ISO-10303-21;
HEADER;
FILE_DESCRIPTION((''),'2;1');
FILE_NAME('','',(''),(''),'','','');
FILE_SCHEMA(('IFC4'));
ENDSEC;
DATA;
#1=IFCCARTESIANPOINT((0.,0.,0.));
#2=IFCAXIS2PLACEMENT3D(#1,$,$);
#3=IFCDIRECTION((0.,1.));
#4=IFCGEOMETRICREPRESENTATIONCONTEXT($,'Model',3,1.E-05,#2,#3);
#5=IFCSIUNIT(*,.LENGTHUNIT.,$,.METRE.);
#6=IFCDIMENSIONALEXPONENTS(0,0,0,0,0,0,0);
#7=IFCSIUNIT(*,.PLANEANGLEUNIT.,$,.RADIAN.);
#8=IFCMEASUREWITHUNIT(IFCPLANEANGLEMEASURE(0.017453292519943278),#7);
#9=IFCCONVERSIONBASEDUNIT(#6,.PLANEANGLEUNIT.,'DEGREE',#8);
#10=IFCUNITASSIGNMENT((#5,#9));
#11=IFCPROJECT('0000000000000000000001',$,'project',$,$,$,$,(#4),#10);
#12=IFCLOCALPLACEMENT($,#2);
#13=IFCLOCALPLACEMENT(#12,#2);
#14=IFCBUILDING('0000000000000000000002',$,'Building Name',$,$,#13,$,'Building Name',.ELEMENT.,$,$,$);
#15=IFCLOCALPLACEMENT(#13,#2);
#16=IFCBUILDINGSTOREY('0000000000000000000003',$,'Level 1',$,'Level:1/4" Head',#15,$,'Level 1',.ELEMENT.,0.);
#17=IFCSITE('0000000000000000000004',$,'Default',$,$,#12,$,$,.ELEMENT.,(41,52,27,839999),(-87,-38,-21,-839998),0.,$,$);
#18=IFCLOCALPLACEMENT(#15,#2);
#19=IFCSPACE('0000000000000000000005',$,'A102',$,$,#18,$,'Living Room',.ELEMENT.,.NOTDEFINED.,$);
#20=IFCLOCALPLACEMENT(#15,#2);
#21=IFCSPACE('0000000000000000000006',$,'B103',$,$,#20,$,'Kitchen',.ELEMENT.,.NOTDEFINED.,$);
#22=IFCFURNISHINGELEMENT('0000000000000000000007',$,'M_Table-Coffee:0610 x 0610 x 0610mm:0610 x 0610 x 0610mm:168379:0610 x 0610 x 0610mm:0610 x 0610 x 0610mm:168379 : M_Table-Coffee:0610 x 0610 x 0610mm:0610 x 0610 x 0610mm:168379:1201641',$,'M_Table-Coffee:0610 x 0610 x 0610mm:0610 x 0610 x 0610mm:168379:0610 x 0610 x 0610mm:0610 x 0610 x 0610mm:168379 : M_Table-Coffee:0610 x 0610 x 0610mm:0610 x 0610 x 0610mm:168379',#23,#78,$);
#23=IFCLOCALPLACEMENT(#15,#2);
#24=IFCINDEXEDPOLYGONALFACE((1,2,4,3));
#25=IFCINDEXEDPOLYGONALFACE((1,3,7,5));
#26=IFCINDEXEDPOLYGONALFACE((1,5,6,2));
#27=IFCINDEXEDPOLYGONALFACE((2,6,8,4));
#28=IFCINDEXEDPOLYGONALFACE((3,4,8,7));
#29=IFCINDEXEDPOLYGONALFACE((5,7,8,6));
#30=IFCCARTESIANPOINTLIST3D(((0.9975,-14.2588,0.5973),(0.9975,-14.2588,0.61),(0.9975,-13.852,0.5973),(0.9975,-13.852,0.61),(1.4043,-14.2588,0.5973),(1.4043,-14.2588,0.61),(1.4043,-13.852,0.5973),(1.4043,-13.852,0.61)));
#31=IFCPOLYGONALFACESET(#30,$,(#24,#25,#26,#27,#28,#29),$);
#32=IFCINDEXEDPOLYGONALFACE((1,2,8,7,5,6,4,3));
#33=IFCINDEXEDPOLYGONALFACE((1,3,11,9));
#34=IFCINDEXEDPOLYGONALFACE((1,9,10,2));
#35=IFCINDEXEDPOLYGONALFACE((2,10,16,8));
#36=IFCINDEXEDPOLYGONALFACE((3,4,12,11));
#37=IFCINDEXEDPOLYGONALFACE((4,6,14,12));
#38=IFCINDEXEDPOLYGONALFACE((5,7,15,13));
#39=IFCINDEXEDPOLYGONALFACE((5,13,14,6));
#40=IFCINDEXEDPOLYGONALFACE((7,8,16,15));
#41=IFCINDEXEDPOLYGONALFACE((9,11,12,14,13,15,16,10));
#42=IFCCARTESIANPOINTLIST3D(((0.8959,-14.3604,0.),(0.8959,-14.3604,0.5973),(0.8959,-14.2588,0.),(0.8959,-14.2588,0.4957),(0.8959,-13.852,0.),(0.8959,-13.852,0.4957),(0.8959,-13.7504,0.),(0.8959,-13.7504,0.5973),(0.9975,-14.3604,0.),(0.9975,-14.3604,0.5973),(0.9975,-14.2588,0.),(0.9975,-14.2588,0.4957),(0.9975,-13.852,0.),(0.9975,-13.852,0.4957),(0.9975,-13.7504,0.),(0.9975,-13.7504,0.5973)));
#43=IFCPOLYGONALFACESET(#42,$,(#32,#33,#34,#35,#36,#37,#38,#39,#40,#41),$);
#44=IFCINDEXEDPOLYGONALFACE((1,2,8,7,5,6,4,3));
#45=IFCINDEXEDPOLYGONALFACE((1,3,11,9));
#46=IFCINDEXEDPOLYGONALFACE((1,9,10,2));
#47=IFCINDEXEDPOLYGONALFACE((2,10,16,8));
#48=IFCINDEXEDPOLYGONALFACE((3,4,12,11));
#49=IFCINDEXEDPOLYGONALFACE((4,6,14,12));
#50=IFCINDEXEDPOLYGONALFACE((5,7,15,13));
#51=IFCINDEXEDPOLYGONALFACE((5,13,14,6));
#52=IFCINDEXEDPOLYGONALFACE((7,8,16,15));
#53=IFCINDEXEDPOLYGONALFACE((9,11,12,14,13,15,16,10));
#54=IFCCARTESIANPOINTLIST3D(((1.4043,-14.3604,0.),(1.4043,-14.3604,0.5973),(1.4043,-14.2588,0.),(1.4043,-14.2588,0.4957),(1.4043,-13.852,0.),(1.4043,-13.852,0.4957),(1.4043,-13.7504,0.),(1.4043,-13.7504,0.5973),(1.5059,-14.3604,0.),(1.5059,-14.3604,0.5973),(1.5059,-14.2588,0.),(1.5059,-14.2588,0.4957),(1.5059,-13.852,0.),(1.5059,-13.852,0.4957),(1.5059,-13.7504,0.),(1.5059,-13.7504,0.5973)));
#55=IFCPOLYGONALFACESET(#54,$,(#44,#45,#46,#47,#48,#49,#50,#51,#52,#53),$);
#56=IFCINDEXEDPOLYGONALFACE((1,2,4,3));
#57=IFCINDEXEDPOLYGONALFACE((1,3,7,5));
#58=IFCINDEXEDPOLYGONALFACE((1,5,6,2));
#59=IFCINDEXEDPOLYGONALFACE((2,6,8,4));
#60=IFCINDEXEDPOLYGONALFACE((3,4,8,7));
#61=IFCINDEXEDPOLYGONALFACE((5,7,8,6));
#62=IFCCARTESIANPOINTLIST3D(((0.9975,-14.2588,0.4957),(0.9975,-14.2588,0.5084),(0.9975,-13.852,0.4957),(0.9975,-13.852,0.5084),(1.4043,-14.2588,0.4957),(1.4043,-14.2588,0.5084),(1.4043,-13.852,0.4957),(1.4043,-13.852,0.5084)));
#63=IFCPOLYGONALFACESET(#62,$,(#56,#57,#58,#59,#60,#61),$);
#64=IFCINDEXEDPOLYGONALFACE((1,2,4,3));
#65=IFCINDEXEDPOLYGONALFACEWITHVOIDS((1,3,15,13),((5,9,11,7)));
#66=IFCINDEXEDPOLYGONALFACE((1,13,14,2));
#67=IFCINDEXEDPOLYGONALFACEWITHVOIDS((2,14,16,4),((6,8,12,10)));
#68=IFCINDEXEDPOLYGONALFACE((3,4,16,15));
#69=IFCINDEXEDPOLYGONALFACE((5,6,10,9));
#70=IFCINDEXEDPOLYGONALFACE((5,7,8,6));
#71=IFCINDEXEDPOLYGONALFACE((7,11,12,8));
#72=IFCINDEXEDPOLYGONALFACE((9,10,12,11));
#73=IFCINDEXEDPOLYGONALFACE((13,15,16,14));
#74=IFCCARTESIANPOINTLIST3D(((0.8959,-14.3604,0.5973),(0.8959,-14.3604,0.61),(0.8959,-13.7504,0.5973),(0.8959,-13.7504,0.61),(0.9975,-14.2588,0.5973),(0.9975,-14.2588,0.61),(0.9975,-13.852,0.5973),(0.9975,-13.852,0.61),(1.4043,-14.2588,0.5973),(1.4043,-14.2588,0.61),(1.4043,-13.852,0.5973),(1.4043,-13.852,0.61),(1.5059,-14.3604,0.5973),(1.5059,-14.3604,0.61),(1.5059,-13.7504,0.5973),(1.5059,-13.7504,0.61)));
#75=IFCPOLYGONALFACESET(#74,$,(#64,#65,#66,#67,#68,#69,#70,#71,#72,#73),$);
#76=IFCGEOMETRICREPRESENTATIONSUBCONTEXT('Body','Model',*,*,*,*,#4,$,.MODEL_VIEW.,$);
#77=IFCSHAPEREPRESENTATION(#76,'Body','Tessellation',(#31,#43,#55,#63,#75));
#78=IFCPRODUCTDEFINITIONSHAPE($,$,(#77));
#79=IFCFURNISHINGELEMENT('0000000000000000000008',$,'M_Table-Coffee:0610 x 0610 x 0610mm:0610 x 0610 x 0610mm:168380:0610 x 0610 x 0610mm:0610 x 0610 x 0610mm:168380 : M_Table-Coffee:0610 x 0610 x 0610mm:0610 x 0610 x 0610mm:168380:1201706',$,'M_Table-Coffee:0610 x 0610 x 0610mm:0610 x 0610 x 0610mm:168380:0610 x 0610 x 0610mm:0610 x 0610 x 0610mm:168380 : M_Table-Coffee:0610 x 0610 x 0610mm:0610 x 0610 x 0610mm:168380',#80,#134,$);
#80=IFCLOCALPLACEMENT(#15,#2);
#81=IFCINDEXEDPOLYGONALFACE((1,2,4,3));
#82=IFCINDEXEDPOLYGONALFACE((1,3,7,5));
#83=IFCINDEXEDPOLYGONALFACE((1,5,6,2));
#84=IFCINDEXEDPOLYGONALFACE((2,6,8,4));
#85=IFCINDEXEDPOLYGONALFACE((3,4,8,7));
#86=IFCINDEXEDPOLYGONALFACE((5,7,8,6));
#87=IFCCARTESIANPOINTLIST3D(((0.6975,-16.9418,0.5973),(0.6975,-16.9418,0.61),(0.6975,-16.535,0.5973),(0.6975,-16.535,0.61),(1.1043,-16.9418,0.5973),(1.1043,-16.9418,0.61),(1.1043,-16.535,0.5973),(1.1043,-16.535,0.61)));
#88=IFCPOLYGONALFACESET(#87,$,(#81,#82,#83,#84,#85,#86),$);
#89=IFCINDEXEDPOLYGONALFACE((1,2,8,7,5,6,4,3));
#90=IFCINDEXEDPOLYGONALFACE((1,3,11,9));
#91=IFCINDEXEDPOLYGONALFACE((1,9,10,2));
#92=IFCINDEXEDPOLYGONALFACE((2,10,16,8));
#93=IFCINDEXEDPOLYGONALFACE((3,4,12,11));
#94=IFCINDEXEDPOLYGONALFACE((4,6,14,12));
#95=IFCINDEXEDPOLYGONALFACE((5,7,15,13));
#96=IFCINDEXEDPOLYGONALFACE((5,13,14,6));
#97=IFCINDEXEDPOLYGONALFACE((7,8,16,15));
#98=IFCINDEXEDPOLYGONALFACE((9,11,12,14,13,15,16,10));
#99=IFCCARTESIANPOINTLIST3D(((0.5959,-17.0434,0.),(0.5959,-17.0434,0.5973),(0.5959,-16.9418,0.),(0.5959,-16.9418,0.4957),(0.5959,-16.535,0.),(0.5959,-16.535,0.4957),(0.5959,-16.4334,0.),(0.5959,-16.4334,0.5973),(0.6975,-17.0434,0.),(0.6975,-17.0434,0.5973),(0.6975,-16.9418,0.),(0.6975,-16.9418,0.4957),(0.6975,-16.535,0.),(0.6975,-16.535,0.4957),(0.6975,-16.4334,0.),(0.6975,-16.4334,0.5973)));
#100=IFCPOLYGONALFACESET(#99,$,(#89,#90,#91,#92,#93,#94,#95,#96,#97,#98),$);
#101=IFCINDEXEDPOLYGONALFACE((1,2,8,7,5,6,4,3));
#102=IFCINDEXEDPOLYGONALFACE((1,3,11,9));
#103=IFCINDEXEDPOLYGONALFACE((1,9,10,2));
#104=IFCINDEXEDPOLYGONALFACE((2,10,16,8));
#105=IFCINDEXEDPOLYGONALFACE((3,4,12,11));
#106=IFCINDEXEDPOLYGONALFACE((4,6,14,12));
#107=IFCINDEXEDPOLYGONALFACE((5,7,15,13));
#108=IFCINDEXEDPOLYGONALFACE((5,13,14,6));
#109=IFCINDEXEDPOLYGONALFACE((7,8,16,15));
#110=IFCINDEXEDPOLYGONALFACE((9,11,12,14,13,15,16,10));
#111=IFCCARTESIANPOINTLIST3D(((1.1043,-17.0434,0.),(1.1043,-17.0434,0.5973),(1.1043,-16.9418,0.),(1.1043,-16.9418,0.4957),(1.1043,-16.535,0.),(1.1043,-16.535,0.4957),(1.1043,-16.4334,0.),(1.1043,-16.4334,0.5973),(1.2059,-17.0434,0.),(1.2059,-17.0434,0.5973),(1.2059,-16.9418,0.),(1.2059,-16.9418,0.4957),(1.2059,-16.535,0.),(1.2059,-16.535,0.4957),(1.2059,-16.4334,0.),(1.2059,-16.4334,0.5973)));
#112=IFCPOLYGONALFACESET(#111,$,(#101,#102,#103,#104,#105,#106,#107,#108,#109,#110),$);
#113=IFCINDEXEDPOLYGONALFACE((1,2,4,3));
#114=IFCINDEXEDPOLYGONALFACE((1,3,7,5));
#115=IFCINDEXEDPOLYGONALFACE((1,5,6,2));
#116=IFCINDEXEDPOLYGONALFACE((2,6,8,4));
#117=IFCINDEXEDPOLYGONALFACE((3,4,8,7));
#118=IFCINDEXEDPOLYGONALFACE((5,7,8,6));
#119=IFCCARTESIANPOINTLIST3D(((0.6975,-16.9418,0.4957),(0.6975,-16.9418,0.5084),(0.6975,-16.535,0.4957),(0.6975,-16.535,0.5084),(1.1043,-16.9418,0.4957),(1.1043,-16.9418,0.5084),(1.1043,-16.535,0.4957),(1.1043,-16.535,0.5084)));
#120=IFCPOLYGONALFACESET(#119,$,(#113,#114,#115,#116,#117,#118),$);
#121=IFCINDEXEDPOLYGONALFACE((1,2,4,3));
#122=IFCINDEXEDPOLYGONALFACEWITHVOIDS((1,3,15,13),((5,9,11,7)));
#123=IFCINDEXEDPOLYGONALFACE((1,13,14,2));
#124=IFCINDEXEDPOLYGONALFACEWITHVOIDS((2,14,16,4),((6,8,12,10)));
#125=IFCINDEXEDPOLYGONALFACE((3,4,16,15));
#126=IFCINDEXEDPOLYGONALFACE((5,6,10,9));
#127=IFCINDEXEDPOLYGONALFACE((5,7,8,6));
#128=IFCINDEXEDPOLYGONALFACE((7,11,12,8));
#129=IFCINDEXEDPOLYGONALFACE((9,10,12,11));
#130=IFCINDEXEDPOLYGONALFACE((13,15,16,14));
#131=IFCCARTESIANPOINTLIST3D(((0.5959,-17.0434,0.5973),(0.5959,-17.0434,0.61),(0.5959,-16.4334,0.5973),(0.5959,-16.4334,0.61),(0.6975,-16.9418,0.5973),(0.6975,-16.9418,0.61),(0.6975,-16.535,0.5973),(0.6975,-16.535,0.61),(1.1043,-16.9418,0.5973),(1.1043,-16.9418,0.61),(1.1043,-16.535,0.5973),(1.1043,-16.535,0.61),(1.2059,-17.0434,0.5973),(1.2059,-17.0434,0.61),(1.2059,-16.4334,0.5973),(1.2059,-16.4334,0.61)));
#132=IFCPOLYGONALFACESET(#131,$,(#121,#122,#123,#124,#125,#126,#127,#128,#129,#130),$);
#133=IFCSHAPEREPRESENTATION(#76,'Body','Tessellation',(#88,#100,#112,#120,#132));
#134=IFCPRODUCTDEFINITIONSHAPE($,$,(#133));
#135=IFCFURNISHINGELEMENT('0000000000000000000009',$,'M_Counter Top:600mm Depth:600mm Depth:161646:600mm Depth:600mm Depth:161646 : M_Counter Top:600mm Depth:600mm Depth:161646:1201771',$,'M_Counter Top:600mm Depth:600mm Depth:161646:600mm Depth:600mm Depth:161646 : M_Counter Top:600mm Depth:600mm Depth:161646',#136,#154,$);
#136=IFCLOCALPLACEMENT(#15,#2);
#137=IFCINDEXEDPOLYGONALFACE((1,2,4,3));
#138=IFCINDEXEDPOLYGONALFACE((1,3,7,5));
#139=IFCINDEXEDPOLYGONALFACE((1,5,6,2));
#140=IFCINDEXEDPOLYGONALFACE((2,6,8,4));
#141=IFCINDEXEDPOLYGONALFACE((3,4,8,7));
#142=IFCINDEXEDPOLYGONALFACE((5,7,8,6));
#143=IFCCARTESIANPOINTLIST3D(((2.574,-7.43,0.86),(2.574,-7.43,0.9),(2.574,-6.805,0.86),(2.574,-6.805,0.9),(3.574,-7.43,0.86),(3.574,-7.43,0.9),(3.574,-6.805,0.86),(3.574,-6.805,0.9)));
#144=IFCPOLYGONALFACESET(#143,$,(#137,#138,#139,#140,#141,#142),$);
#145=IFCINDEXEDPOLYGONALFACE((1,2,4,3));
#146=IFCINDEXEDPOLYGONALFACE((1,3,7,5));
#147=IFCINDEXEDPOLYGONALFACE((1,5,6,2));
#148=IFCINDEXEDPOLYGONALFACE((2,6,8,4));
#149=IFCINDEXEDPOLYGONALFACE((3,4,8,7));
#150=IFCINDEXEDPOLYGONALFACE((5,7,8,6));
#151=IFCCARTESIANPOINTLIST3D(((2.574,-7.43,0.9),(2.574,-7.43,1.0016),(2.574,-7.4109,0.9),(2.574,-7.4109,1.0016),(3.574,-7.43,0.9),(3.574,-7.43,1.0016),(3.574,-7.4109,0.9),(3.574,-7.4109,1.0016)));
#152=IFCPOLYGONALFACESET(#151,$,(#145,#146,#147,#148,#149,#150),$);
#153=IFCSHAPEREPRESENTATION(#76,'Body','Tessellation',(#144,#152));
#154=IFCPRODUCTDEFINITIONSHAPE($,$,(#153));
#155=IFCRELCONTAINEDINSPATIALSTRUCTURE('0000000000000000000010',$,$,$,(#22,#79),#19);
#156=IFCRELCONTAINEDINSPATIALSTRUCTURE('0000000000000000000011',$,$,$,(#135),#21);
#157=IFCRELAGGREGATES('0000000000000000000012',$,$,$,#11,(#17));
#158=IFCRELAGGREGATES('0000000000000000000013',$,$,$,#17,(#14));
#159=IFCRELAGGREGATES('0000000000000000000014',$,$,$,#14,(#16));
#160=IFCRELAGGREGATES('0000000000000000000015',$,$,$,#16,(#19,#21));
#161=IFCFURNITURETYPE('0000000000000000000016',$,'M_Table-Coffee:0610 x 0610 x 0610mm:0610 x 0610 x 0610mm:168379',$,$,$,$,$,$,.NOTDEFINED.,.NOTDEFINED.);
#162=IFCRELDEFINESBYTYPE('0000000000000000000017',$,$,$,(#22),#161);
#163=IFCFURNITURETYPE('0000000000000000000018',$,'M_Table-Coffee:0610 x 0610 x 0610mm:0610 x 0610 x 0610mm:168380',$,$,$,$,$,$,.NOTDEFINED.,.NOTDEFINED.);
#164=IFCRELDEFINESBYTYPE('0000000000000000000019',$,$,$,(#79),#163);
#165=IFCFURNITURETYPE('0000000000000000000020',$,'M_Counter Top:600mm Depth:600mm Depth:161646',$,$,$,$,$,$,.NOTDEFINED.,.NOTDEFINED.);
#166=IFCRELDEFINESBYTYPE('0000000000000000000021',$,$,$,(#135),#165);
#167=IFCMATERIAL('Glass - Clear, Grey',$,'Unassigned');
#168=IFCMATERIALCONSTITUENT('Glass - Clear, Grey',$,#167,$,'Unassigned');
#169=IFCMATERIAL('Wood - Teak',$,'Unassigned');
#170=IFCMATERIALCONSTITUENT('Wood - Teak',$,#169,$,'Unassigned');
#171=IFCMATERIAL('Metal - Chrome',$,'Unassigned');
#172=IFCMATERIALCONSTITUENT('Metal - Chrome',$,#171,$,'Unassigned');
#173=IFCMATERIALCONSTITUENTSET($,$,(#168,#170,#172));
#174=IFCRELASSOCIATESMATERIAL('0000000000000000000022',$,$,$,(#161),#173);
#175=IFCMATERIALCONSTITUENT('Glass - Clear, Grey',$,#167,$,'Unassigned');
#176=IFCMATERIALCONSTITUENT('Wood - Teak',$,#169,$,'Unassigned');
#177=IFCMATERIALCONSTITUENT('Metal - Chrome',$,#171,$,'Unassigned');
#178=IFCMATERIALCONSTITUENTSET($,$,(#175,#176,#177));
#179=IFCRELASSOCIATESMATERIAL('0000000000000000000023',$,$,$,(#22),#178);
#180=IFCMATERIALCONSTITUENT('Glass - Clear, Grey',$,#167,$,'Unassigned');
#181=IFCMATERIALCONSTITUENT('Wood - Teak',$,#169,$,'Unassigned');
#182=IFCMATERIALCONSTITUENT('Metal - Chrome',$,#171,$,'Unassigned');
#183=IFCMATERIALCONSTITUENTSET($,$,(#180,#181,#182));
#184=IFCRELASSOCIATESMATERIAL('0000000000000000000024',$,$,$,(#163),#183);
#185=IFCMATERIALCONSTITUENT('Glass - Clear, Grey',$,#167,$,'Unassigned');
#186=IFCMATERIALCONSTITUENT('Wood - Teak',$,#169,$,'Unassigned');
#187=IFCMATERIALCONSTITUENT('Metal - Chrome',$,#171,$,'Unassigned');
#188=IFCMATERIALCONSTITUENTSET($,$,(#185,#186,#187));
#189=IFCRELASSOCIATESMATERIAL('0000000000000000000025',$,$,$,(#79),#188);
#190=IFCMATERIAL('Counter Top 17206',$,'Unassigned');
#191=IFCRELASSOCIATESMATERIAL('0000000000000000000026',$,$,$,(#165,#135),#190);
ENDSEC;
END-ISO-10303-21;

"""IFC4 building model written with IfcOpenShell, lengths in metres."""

from ifc_helpers import new_model, entity, si_unit, converted_unit, direction, frame, origin, place, context, subcontext, project, spatial, indexed_curve, outline, extrude, source, transform, mapped, material, constituent, constituent_set, type_object, type_shapes, element, save


model = new_model("IFC4")

# Units and contexts
model_context = context("Model", 3, precision=1e-05, world=origin(), true_north=direction((0.0, 1.0)))
body_context = subcontext(model_context, "Body", "Model", "MODEL_VIEW")
ifc_project = project(units=[si_unit("LENGTHUNIT", "METRE"), converted_unit("PLANEANGLEUNIT", "DEGREE", entity("IfcPlaneAngleMeasure", 0.017453292519943278), si_unit("PLANEANGLEUNIT", "RADIAN"), dimensions=[0, 0, 0, 0, 0, 0, 0])], contexts=[model_context])

# Site, building, storey
site_placement = place(None, origin())
site = spatial("IfcSite", under=ifc_project, at=site_placement, Name="Default", CompositionType="ELEMENT", RefLatitude=(41, 52, 27, 839999), RefLongitude=(-87, -38, -21, -839998), RefElevation=0.0)
building_placement = place(site_placement, origin())
building = spatial("IfcBuilding", under=site, at=building_placement, Name="Building Name", LongName="Building Name", CompositionType="ELEMENT")
storey_placement = place(building_placement, origin())
storey = spatial("IfcBuildingStorey", under=building, at=storey_placement, Name="Level 1", ObjectType="Level:1/4\" Head", LongName="Level 1", CompositionType="ELEMENT", Elevation=0.0)

# Shared definitions
ifc_material_1 = material(Name="Glass - Clear, Grey", Category="Unassigned")
ifc_material_2 = material(Name="Wood - Teak", Category="Unassigned")
ifc_material_3 = material(Name="Metal - Chrome", Category="Unassigned")

# Shared definitions
space_1_placement = place(storey_placement, origin())
space_1 = spatial("IfcSpace", under=storey, at=space_1_placement, Name="A102", LongName="Living Room", CompositionType="ELEMENT", PredefinedType="NOTDEFINED")

# Furnishing elements
ifc_constituent_1 = constituent(ifc_material_1, Name="Glass - Clear, Grey", Category="Unassigned")
ifc_constituent_2 = constituent(ifc_material_2, Name="Wood - Teak", Category="Unassigned")
ifc_constituent_3 = constituent(ifc_material_3, Name="Metal - Chrome", Category="Unassigned")
ifc_constituent_set_1 = constituent_set(constituents=[ifc_constituent_1, ifc_constituent_2, ifc_constituent_3])
ifc_constituent_4 = constituent(ifc_material_1, Name="Glass - Clear, Grey", Category="Unassigned")
ifc_constituent_5 = constituent(ifc_material_2, Name="Wood - Teak", Category="Unassigned")
ifc_constituent_6 = constituent(ifc_material_3, Name="Metal - Chrome", Category="Unassigned")
ifc_constituent_set_2 = constituent_set(constituents=[ifc_constituent_4, ifc_constituent_5, ifc_constituent_6])
furniture_type_1 = type_object("IfcFurnitureType", Name="M_Table-Coffee:0610 x 0610 x 0610mm:0610 x 0610 x 0610mm:168379", AssemblyPlace="NOTDEFINED", PredefinedType="NOTDEFINED", material=ifc_constituent_set_2)
shared_shape_1 = source(origin(), body_context, "Body", "SweptSolid", [
    extrude(outline(indexed_curve([(-0.2034, -0.2034), (0.2034, -0.2034), (0.2034, 0.2034), (-0.2034, 0.2034), (-0.2034, -0.2034)], self_intersect=False)), frame((1.2009, -14.0554, 0.5973), z_axis=(0.0, 0.0, 1.0), x_axis=(0.0, 1.0, 0.0)), (0.0, 0.0, 1.0), 0.0127),
    extrude(outline(indexed_curve([(-0.324, -0.305), (0.2732, -0.305), (0.2732, -0.2034), (-0.2225, -0.2034), (-0.2225, 0.2034), (0.2732, 0.2034), (0.2732, 0.305), (-0.324, 0.305), (-0.324, -0.305)], self_intersect=False)), frame((0.8959, -14.0554, 0.2732), z_axis=(1.0, 0.0, 0.0), x_axis=(0.0, 0.0, -1.0)), (0.0, 0.0, 1.0), 0.1016),
    extrude(outline(indexed_curve([(-0.305, -0.3241), (0.305, -0.3241), (0.305, 0.2733), (0.2034, 0.2733), (0.2034, -0.2224), (-0.2034, -0.2224), (-0.2034, 0.2733), (-0.305, 0.2733), (-0.305, -0.3241)], self_intersect=False)), frame((1.4043, -14.0554, 0.2733), z_axis=(1.0, 0.0, 0.0), x_axis=(0.0, -1.0, 0.0)), (0.0, 0.0, 1.0), 0.1016),
    extrude(outline(indexed_curve([(-0.2034, -0.2034), (0.2034, -0.2034), (0.2034, 0.2034), (-0.2034, 0.2034), (-0.2034, -0.2034)], self_intersect=False)), frame((1.2009, -14.0554, 0.4957), z_axis=(0.0, 0.0, 1.0), x_axis=(0.0, 1.0, 0.0)), (0.0, 0.0, 1.0), 0.0127),
    extrude(outline(indexed_curve([(-0.305, -0.305), (0.305, -0.305), (0.305, 0.305), (-0.305, 0.305), (-0.305, -0.305)], self_intersect=False), holes=[indexed_curve([(0.2034, 0.2034), (0.2034, -0.2034), (-0.2034, -0.2034), (-0.2034, 0.2034), (0.2034, 0.2034)], self_intersect=False)]), frame((1.2009, -14.0554, 0.5973), z_axis=(0.0, 0.0, 1.0), x_axis=(0.0, 1.0, 0.0)), (0.0, 0.0, 1.0), 0.0127),
])
type_shapes(furniture_type_1, [shared_shape_1])
furnishing_1_placement = place(space_1_placement, origin())
element("IfcFurnishingElement", 1, at=furnishing_1_placement, inside=space_1, type_object=furniture_type_1, material=ifc_constituent_set_1, Name="M_Table-Coffee:0610 x 0610 x 0610mm:0610 x 0610 x 0610mm:168379:0610 x 0610 x 0610mm:0610 x 0610 x 0610mm:168379 : M_Table-Coffee:0610 x 0610 x 0610mm:0610 x 0610 x 0610mm:168379:1201641", ObjectType="M_Table-Coffee:0610 x 0610 x 0610mm:0610 x 0610 x 0610mm:168379:0610 x 0610 x 0610mm:0610 x 0610 x 0610mm:168379 : M_Table-Coffee:0610 x 0610 x 0610mm:0610 x 0610 x 0610mm:168379", context=body_context, shape_type="MappedRepresentation", body=[
    mapped(shared_shape_1, transform((0.0, 0.0, 0.0), scale=1.0)),
])
ifc_constituent_7 = constituent(ifc_material_1, Name="Glass - Clear, Grey", Category="Unassigned")
ifc_constituent_8 = constituent(ifc_material_2, Name="Wood - Teak", Category="Unassigned")
ifc_constituent_9 = constituent(ifc_material_3, Name="Metal - Chrome", Category="Unassigned")
ifc_constituent_set_3 = constituent_set(constituents=[ifc_constituent_7, ifc_constituent_8, ifc_constituent_9])
ifc_constituent_10 = constituent(ifc_material_1, Name="Glass - Clear, Grey", Category="Unassigned")
ifc_constituent_11 = constituent(ifc_material_2, Name="Wood - Teak", Category="Unassigned")
ifc_constituent_12 = constituent(ifc_material_3, Name="Metal - Chrome", Category="Unassigned")
ifc_constituent_set_4 = constituent_set(constituents=[ifc_constituent_10, ifc_constituent_11, ifc_constituent_12])
furniture_type_2 = type_object("IfcFurnitureType", Name="M_Table-Coffee:0610 x 0610 x 0610mm:0610 x 0610 x 0610mm:168380", AssemblyPlace="NOTDEFINED", PredefinedType="NOTDEFINED", material=ifc_constituent_set_4)
shared_shape_2 = source(origin(), body_context, "Body", "SweptSolid", [
    extrude(outline(indexed_curve([(-0.2034, -0.2034), (0.2034, -0.2034), (0.2034, 0.2034), (-0.2034, 0.2034), (-0.2034, -0.2034)], self_intersect=False)), frame((0.9009, -16.7384, 0.5973), z_axis=(0.0, 0.0, 1.0), x_axis=(0.0, 1.0, 0.0)), (0.0, 0.0, 1.0), 0.0127),
    extrude(outline(indexed_curve([(-0.324, -0.305), (0.2732, -0.305), (0.2732, -0.2034), (-0.2225, -0.2034), (-0.2225, 0.2034), (0.2732, 0.2034), (0.2732, 0.305), (-0.324, 0.305), (-0.324, -0.305)], self_intersect=False)), frame((0.5959, -16.7384, 0.2732), z_axis=(1.0, 0.0, 0.0), x_axis=(0.0, 0.0, -1.0)), (0.0, 0.0, 1.0), 0.1016),
    extrude(outline(indexed_curve([(-0.305, -0.3241), (0.305, -0.3241), (0.305, 0.2733), (0.2034, 0.2733), (0.2034, -0.2224), (-0.2034, -0.2224), (-0.2034, 0.2733), (-0.305, 0.2733), (-0.305, -0.3241)], self_intersect=False)), frame((1.1043, -16.7384, 0.2733), z_axis=(1.0, 0.0, 0.0), x_axis=(0.0, -1.0, 0.0)), (0.0, 0.0, 1.0), 0.1016),
    extrude(outline(indexed_curve([(-0.2034, -0.2034), (0.2034, -0.2034), (0.2034, 0.2034), (-0.2034, 0.2034), (-0.2034, -0.2034)], self_intersect=False)), frame((0.9009, -16.7384, 0.4957), z_axis=(0.0, 0.0, 1.0), x_axis=(0.0, 1.0, 0.0)), (0.0, 0.0, 1.0), 0.0127),
    extrude(outline(indexed_curve([(-0.305, -0.305), (0.305, -0.305), (0.305, 0.305), (-0.305, 0.305), (-0.305, -0.305)], self_intersect=False), holes=[indexed_curve([(0.2034, 0.2034), (0.2034, -0.2034), (-0.2034, -0.2034), (-0.2034, 0.2034), (0.2034, 0.2034)], self_intersect=False)]), frame((0.9009, -16.7384, 0.5973), z_axis=(0.0, 0.0, 1.0), x_axis=(0.0, 1.0, 0.0)), (0.0, 0.0, 1.0), 0.0127),
])
type_shapes(furniture_type_2, [shared_shape_2])
furnishing_2_placement = place(space_1_placement, origin())
element("IfcFurnishingElement", 2, at=furnishing_2_placement, inside=space_1, type_object=furniture_type_2, material=ifc_constituent_set_3, Name="M_Table-Coffee:0610 x 0610 x 0610mm:0610 x 0610 x 0610mm:168380:0610 x 0610 x 0610mm:0610 x 0610 x 0610mm:168380 : M_Table-Coffee:0610 x 0610 x 0610mm:0610 x 0610 x 0610mm:168380:1201706", ObjectType="M_Table-Coffee:0610 x 0610 x 0610mm:0610 x 0610 x 0610mm:168380:0610 x 0610 x 0610mm:0610 x 0610 x 0610mm:168380 : M_Table-Coffee:0610 x 0610 x 0610mm:0610 x 0610 x 0610mm:168380", context=body_context, shape_type="MappedRepresentation", body=[
    mapped(shared_shape_2, transform((0.0, 0.0, 0.0), scale=1.0)),
])

# Shared definitions
space_2_placement = place(storey_placement, origin())
space_2 = spatial("IfcSpace", under=storey, at=space_2_placement, Name="B103", LongName="Kitchen", CompositionType="ELEMENT", PredefinedType="NOTDEFINED")

# Furnishing element
ifc_material_4 = material(Name="Counter Top 17206", Category="Unassigned")
furniture_type_3 = type_object("IfcFurnitureType", Name="M_Counter Top:600mm Depth:600mm Depth:161646", AssemblyPlace="NOTDEFINED", PredefinedType="NOTDEFINED", material=ifc_material_4)
shared_shape_3 = source(origin(), body_context, "Body", "SweptSolid", [
    extrude(outline(indexed_curve([(-0.3125, -0.5), (0.3125, -0.5), (0.3125, 0.5), (-0.3125, 0.5), (-0.3125, -0.5)], self_intersect=False)), frame((3.074, -7.1175, 0.86), z_axis=(0.0, 0.0, 1.0), x_axis=(0.0, 1.0, 0.0)), (0.0, 0.0, 1.0), 0.04),
    extrude(outline(indexed_curve([(-0.5, -0.0095), (0.5, -0.0095), (0.5, 0.0095), (-0.5, 0.0095), (-0.5, -0.0095)], self_intersect=False)), frame((3.074, -7.4205, 0.9), z_axis=(0.0, 0.0, 1.0), x_axis=(-1.0, 0.0, 0.0)), (0.0, 0.0, 1.0), 0.1016),
])
type_shapes(furniture_type_3, [shared_shape_3])
furnishing_3_placement = place(space_2_placement, origin())
element("IfcFurnishingElement", 3, at=furnishing_3_placement, inside=space_2, type_object=furniture_type_3, material=ifc_material_4, Name="M_Counter Top:600mm Depth:600mm Depth:161646:600mm Depth:600mm Depth:161646 : M_Counter Top:600mm Depth:600mm Depth:161646:1201771", ObjectType="M_Counter Top:600mm Depth:600mm Depth:161646:600mm Depth:600mm Depth:161646 : M_Counter Top:600mm Depth:600mm Depth:161646", context=body_context, shape_type="MappedRepresentation", body=[
    mapped(shared_shape_3, transform((0.0, 0.0, 0.0), scale=1.0)),
])

save(model, "model.ifc")
